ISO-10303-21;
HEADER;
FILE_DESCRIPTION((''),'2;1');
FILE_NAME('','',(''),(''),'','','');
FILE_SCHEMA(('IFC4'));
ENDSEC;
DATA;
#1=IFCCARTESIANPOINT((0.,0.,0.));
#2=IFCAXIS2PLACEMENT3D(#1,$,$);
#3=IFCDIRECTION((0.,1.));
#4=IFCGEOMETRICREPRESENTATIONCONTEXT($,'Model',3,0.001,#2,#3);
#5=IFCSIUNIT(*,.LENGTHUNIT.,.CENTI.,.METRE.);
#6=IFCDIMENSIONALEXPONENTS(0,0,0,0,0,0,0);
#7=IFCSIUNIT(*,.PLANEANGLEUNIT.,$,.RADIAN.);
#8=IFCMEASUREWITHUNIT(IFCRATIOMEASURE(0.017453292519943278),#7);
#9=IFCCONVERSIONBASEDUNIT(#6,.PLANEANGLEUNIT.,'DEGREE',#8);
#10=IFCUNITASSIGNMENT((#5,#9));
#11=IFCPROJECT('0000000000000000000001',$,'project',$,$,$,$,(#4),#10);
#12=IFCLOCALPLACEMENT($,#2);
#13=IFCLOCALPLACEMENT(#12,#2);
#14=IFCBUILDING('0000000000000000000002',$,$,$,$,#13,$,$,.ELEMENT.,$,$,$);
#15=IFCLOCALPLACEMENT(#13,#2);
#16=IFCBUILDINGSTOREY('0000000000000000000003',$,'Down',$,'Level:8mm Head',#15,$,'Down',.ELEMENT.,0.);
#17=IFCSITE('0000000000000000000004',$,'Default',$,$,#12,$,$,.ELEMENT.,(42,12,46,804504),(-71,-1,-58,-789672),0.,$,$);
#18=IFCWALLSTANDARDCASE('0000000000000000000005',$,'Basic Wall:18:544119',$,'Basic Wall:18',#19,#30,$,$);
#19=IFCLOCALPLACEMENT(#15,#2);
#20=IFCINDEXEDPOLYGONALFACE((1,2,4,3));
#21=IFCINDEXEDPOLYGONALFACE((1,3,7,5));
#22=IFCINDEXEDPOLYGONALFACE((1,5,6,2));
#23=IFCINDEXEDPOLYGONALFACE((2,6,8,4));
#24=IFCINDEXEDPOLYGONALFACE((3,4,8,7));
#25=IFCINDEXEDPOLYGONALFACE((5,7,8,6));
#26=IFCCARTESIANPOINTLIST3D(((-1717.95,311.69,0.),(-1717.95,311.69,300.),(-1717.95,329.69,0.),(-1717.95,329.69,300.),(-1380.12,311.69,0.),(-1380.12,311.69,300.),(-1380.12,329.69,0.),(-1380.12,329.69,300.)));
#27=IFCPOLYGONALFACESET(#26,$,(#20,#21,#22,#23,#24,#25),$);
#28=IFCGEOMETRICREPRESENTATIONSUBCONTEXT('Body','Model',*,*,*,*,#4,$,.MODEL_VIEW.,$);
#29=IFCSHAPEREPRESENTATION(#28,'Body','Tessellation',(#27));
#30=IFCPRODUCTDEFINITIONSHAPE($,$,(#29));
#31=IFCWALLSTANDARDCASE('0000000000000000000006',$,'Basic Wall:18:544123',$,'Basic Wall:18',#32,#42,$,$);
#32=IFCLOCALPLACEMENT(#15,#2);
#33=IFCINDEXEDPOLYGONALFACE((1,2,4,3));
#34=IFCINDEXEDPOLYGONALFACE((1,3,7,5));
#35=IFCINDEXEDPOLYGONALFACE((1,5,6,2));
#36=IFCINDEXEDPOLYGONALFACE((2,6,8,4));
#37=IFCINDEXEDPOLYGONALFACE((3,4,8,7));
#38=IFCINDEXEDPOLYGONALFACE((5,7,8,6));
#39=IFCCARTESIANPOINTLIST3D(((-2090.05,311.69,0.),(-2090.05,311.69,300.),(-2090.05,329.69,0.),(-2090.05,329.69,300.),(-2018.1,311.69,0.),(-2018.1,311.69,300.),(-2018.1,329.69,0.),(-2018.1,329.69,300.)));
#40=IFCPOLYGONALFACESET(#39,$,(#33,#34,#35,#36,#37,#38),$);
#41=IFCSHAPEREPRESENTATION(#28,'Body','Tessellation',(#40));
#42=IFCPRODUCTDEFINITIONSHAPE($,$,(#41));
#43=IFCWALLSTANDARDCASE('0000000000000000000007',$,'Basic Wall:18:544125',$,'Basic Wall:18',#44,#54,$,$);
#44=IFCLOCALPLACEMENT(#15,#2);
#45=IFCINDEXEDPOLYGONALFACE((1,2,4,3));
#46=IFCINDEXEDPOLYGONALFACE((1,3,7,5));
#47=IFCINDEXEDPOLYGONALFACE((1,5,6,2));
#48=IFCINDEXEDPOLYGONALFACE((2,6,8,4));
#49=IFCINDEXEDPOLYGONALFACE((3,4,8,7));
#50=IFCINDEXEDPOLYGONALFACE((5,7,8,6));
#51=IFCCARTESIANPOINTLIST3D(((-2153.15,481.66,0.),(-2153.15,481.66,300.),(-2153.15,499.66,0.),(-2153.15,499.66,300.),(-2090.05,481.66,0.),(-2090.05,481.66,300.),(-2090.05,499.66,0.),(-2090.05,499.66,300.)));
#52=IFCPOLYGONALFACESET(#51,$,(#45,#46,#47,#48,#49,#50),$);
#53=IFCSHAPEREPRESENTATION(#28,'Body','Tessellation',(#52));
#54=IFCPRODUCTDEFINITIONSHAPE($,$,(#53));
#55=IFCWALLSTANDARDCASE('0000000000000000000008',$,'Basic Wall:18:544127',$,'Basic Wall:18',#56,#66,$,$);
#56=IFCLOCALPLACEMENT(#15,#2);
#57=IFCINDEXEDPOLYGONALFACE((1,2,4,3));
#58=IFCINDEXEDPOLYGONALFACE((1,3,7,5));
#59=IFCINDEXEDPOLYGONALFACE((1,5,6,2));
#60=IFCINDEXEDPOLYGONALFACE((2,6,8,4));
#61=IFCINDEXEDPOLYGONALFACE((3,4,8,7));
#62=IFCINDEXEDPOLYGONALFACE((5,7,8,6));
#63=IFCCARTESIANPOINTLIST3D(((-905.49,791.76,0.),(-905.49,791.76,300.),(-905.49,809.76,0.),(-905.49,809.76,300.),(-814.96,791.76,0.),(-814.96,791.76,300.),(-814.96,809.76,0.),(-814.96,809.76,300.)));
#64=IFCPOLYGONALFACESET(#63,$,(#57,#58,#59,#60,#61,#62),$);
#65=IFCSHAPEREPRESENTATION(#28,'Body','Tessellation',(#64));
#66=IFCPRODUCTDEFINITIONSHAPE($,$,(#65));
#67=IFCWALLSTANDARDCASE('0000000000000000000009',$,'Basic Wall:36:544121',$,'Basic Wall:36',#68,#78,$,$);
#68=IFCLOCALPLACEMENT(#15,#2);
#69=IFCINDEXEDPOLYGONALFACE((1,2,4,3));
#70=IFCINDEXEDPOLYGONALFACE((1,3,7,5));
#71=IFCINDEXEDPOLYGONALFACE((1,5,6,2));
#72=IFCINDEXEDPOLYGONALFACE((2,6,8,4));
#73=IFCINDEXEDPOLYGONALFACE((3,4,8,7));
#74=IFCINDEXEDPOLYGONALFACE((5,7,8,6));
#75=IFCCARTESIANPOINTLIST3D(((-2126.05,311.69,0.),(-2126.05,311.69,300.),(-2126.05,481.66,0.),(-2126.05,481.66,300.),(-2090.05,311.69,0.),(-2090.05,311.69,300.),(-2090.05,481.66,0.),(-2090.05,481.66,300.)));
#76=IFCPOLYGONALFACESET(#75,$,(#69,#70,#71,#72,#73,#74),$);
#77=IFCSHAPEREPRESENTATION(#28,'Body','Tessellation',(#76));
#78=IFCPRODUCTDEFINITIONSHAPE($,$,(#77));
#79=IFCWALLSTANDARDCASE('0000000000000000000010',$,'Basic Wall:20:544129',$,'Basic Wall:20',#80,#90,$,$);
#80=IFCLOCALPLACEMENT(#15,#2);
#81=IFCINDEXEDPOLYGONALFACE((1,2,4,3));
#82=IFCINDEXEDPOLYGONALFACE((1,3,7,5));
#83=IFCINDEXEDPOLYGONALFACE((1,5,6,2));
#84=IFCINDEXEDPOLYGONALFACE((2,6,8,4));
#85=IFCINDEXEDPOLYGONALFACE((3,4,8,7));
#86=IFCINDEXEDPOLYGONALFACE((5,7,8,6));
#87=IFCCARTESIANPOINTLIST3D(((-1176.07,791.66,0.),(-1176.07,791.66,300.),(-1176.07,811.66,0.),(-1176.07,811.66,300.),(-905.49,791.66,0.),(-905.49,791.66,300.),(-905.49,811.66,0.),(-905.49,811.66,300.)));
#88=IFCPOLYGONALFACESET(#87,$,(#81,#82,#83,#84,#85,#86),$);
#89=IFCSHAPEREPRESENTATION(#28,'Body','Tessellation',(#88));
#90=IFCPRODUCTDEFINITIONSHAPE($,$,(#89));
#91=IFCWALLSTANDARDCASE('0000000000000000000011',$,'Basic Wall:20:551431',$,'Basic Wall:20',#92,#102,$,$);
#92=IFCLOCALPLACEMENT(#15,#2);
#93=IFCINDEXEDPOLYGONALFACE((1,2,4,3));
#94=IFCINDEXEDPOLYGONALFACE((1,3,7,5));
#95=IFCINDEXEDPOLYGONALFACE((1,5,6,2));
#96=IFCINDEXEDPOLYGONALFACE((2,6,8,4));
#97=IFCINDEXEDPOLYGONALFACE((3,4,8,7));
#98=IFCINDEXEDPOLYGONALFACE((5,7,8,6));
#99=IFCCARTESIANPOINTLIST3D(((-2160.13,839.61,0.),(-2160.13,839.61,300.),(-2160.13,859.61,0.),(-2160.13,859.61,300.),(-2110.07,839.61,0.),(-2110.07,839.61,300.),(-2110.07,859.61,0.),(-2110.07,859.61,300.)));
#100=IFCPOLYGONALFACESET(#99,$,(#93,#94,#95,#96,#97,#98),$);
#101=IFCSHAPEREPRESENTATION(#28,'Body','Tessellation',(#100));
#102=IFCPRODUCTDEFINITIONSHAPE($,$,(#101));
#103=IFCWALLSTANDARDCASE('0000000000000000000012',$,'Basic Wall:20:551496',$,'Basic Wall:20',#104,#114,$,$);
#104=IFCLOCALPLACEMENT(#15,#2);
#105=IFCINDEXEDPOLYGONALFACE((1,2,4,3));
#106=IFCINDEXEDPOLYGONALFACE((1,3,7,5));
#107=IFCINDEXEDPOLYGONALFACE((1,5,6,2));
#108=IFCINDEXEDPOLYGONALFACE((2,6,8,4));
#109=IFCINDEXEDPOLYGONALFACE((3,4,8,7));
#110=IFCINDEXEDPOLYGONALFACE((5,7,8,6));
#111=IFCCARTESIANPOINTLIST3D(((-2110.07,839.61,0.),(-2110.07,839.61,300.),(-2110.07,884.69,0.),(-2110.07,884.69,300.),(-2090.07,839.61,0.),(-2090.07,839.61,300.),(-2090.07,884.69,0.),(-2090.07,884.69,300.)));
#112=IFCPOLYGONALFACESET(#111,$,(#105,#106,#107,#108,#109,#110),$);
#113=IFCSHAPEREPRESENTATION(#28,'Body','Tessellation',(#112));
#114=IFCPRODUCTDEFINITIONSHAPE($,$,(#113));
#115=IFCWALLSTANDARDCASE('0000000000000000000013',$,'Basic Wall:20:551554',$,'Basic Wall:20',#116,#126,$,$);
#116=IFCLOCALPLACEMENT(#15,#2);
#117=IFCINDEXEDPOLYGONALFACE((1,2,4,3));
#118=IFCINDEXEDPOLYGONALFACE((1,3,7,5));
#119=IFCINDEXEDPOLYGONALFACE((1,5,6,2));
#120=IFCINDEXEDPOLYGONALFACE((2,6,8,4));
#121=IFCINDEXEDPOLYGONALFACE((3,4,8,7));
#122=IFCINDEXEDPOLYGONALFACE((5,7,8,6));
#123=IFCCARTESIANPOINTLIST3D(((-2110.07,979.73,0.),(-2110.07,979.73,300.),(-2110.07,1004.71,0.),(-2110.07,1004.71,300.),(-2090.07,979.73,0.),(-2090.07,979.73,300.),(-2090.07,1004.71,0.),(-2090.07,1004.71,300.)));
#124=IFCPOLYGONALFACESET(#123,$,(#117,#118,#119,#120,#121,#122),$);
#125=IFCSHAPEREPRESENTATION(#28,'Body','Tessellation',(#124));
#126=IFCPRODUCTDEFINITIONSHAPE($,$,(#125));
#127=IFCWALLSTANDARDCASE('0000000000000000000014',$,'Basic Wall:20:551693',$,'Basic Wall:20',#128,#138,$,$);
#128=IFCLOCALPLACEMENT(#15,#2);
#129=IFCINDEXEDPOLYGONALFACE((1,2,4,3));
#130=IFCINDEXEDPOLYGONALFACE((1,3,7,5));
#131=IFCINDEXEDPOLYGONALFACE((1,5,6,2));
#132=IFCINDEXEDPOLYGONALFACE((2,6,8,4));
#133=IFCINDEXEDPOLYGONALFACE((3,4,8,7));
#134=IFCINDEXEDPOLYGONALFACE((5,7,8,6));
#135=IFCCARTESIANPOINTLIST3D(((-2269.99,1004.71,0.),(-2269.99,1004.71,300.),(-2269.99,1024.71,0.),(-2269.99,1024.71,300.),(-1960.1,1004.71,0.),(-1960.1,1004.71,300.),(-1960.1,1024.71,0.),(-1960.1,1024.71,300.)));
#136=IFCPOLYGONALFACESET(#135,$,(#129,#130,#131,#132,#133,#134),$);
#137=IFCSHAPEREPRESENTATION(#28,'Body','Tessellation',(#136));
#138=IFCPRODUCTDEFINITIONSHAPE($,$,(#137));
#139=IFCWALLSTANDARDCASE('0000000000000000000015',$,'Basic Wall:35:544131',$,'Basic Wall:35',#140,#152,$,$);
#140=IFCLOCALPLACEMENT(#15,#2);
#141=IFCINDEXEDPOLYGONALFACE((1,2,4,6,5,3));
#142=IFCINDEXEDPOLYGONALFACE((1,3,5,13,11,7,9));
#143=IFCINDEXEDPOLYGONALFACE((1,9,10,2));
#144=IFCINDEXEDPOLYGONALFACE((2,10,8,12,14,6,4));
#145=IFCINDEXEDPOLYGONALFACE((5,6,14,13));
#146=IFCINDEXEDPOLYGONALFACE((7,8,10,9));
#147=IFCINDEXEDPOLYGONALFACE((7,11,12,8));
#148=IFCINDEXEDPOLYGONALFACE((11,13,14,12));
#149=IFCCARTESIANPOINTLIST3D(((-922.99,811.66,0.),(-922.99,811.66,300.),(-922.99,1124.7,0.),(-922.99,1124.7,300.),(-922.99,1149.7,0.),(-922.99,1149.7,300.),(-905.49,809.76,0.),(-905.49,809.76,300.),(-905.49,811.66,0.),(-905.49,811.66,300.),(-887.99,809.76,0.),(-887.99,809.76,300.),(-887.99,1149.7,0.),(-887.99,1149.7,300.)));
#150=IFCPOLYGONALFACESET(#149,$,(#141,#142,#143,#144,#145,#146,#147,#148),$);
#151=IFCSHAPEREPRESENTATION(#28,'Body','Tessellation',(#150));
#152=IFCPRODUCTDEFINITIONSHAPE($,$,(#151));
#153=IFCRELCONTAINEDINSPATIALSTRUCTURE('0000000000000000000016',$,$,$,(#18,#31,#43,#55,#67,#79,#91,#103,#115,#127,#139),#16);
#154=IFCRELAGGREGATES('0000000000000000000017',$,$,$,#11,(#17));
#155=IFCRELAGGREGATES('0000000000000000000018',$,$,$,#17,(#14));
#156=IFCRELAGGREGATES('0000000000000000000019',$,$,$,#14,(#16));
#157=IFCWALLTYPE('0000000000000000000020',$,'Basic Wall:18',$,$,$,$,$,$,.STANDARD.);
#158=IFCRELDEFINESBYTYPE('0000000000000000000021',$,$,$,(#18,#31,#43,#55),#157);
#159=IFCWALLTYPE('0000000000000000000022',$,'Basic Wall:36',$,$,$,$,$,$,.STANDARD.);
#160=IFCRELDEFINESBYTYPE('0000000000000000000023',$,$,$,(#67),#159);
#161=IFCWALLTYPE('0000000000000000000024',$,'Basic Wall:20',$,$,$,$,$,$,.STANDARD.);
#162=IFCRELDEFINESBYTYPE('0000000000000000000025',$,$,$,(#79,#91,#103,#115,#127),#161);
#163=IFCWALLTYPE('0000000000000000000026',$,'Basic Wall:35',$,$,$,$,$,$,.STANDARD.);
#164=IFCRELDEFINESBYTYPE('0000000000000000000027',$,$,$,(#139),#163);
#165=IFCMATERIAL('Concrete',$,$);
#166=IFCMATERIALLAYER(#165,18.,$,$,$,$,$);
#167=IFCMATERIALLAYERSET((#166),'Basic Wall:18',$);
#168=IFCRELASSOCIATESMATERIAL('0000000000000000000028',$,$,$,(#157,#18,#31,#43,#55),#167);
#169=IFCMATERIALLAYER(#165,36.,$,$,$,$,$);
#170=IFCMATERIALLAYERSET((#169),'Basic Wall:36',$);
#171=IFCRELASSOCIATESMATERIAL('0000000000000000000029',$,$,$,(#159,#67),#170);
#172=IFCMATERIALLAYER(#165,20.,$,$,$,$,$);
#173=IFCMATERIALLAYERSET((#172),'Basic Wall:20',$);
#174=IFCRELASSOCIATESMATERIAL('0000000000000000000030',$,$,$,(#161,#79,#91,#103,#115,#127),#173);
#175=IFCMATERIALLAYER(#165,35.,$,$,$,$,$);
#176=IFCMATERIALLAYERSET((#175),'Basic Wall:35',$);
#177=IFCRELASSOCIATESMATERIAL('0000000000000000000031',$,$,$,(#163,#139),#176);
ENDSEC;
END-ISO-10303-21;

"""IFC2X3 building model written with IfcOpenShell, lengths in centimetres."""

from ifc_helpers import new_model, entity, si_unit, converted_unit, direction, frame, frame_2d, origin, place, context, subcontext, project, spatial, polyline, rectangle, outline, extrude, material, layer, layer_set, layer_usage, type_object, element, save


model = new_model("IFC2X3")

# Units and contexts
model_context = context("Model", 3, precision=0.001, world=origin(), true_north=direction((0.0, 1.0)))
body_context = subcontext(model_context, "Body", "Model", "MODEL_VIEW")
ifc_project = project(units=[si_unit("LENGTHUNIT", "METRE", prefix="CENTI"), converted_unit("PLANEANGLEUNIT", "DEGREE", entity("IfcRatioMeasure", 0.017453292519943278), si_unit("PLANEANGLEUNIT", "RADIAN"), dimensions=[0, 0, 0, 0, 0, 0, 0])], contexts=[model_context])

# Site, building, storey
site_placement = place(None, origin())
site = spatial("IfcSite", under=ifc_project, at=site_placement, Name="Default", CompositionType="ELEMENT", RefLatitude=(42, 12, 46, 804504), RefLongitude=(-71, -1, -58, -789672), RefElevation=0.0)
building_placement = place(site_placement, origin())
building = spatial("IfcBuilding", under=site, at=building_placement, CompositionType="ELEMENT")
storey_placement = place(building_placement, origin())
storey = spatial("IfcBuildingStorey", under=building, at=storey_placement, Name="Down", ObjectType="Level:8mm Head", LongName="Down", CompositionType="ELEMENT", Elevation=0.0)

# Shared definitions
ifc_material = material(Name="Concrete")

# Walls
ifc_layer_1 = layer(ifc_material, 18.0)
ifc_layer_set_1 = layer_set([ifc_layer_1], Name="Basic Wall:18")
wall_type_1 = type_object("IfcWallType", Name="Basic Wall:18", PredefinedType="STANDARD", material=ifc_layer_set_1)
ifc_layer_usage_1 = layer_usage(ifc_layer_set_1, "AXIS2", "POSITIVE", -9.0)
wall_1_placement = place(storey_placement, frame((-1380.12, 320.69, 0.0), z_axis=(0.0, 0.0, 1.0), x_axis=(-1.0, 0.0, 0.0)))
element("IfcWallStandardCase", 1, at=wall_1_placement, inside=storey, type_object=wall_type_1, material=ifc_layer_usage_1, Name="Basic Wall:18:544119", ObjectType="Basic Wall:18", context=body_context, shape_type="SweptSolid", body=[
    extrude(rectangle(XDim=337.83, YDim=18.0, at=frame_2d((168.91, 0.0), x_axis=(-1.0, 0.0))), origin(), (0.0, 0.0, 1.0), 300.0),
])
ifc_layer_usage_2 = layer_usage(ifc_layer_set_1, "AXIS2", "POSITIVE", -9.0)
wall_2_placement = place(storey_placement, frame((-2018.1, 320.69, 0.0), z_axis=(0.0, 0.0, 1.0), x_axis=(-1.0, 0.0, 0.0)))
element("IfcWallStandardCase", 2, at=wall_2_placement, inside=storey, type_object=wall_type_1, material=ifc_layer_usage_2, Name="Basic Wall:18:544123", ObjectType="Basic Wall:18", context=body_context, shape_type="SweptSolid", body=[
    extrude(rectangle(XDim=71.95, YDim=18.0, at=frame_2d((35.98, 0.0), x_axis=(-1.0, 0.0))), origin(), (0.0, 0.0, 1.0), 300.0),
])
ifc_layer_usage_3 = layer_usage(ifc_layer_set_1, "AXIS2", "POSITIVE", -9.0)
wall_3_placement = place(storey_placement, frame((-2090.05, 490.66, 0.0), z_axis=(0.0, 0.0, 1.0), x_axis=(-1.0, 0.0, 0.0)))
element("IfcWallStandardCase", 3, at=wall_3_placement, inside=storey, type_object=wall_type_1, material=ifc_layer_usage_3, Name="Basic Wall:18:544125", ObjectType="Basic Wall:18", context=body_context, shape_type="SweptSolid", body=[
    extrude(rectangle(XDim=63.09, YDim=18.0, at=frame_2d((31.55, 0.0), x_axis=(-1.0, 0.0))), origin(), (0.0, 0.0, 1.0), 300.0),
])
ifc_layer_usage_4 = layer_usage(ifc_layer_set_1, "AXIS2", "POSITIVE", -9.0)
wall_4_placement = place(storey_placement, frame((-814.96, 800.76, 0.0), z_axis=(0.0, 0.0, 1.0), x_axis=(-1.0, 0.0, 0.0)))
element("IfcWallStandardCase", 4, at=wall_4_placement, inside=storey, type_object=wall_type_1, material=ifc_layer_usage_4, Name="Basic Wall:18:544127", ObjectType="Basic Wall:18", context=body_context, shape_type="SweptSolid", body=[
    extrude(rectangle(XDim=90.53, YDim=18.0, at=frame_2d((45.26, 0.0), x_axis=(-1.0, 0.0))), origin(), (0.0, 0.0, 1.0), 300.0),
])
ifc_layer_2 = layer(ifc_material, 36.0)
ifc_layer_set_2 = layer_set([ifc_layer_2], Name="Basic Wall:36")
ifc_layer_usage_5 = layer_usage(ifc_layer_set_2, "AXIS2", "NEGATIVE", 18.0)
wall_type_2 = type_object("IfcWallType", Name="Basic Wall:36", PredefinedType="STANDARD", material=ifc_layer_set_2)
wall_5_placement = place(storey_placement, frame((-2108.05, 311.69, 0.0), z_axis=(0.0, 0.0, 1.0), x_axis=(0.0, 1.0, 0.0)))
element("IfcWallStandardCase", 5, at=wall_5_placement, inside=storey, type_object=wall_type_2, material=ifc_layer_usage_5, Name="Basic Wall:36:544121", ObjectType="Basic Wall:36", context=body_context, shape_type="SweptSolid", body=[
    extrude(rectangle(XDim=169.97, YDim=36.0, at=frame_2d((84.99, 0.0), x_axis=(-1.0, 0.0))), origin(), (0.0, 0.0, 1.0), 300.0),
])
ifc_layer_3 = layer(ifc_material, 20.0)
ifc_layer_set_3 = layer_set([ifc_layer_3], Name="Basic Wall:20")
ifc_layer_usage_6 = layer_usage(ifc_layer_set_3, "AXIS2", "NEGATIVE", 10.0)
wall_type_3 = type_object("IfcWallType", Name="Basic Wall:20", PredefinedType="STANDARD", material=ifc_layer_set_3)
wall_6_placement = place(storey_placement, frame((-1176.07, 801.66, 0.0)))
element("IfcWallStandardCase", 6, at=wall_6_placement, inside=storey, type_object=wall_type_3, material=ifc_layer_usage_6, Name="Basic Wall:20:544129", ObjectType="Basic Wall:20", context=body_context, shape_type="SweptSolid", body=[
    extrude(rectangle(XDim=270.58, YDim=20.0, at=frame_2d((135.29, 0.0), x_axis=(-1.0, 0.0))), origin(), (0.0, 0.0, 1.0), 300.0),
])
ifc_layer_usage_7 = layer_usage(ifc_layer_set_3, "AXIS2", "POSITIVE", -10.0)
wall_7_placement = place(storey_placement, frame((-2160.13, 849.61, 0.0)))
element("IfcWallStandardCase", 7, at=wall_7_placement, inside=storey, type_object=wall_type_3, material=ifc_layer_usage_7, Name="Basic Wall:20:551431", ObjectType="Basic Wall:20", context=body_context, shape_type="SweptSolid", body=[
    extrude(rectangle(XDim=50.06, YDim=20.0, at=frame_2d((25.03, 0.0), x_axis=(-1.0, 0.0))), origin(), (0.0, 0.0, 1.0), 300.0),
])
ifc_layer_usage_8 = layer_usage(ifc_layer_set_3, "AXIS2", "POSITIVE", -10.0)
wall_8_placement = place(storey_placement, frame((-2100.07, 839.61, 0.0), z_axis=(0.0, 0.0, 1.0), x_axis=(0.0, 1.0, 0.0)))
element("IfcWallStandardCase", 8, at=wall_8_placement, inside=storey, type_object=wall_type_3, material=ifc_layer_usage_8, Name="Basic Wall:20:551496", ObjectType="Basic Wall:20", context=body_context, shape_type="SweptSolid", body=[
    extrude(rectangle(XDim=45.09, YDim=20.0, at=frame_2d((22.54, 0.0), x_axis=(-1.0, 0.0))), origin(), (0.0, 0.0, 1.0), 300.0),
])
ifc_layer_usage_9 = layer_usage(ifc_layer_set_3, "AXIS2", "POSITIVE", -10.0)
wall_9_placement = place(storey_placement, frame((-2100.07, 979.73, 0.0), z_axis=(0.0, 0.0, 1.0), x_axis=(0.0, 1.0, 0.0)))
element("IfcWallStandardCase", 9, at=wall_9_placement, inside=storey, type_object=wall_type_3, material=ifc_layer_usage_9, Name="Basic Wall:20:551554", ObjectType="Basic Wall:20", context=body_context, shape_type="SweptSolid", body=[
    extrude(rectangle(XDim=24.98, YDim=20.0, at=frame_2d((12.49, 0.0), x_axis=(-1.0, 0.0))), origin(), (0.0, 0.0, 1.0), 300.0),
])
ifc_layer_usage_10 = layer_usage(ifc_layer_set_3, "AXIS2", "NEGATIVE", 10.0)
wall_10_placement = place(storey_placement, frame((-1960.1, 1014.71, 0.0), z_axis=(0.0, 0.0, 1.0), x_axis=(-1.0, 0.0, 0.0)))
element("IfcWallStandardCase", 10, at=wall_10_placement, inside=storey, type_object=wall_type_3, material=ifc_layer_usage_10, Name="Basic Wall:20:551693", ObjectType="Basic Wall:20", context=body_context, shape_type="SweptSolid", body=[
    extrude(rectangle(XDim=309.89, YDim=20.0, at=frame_2d((154.94, 0.0), x_axis=(-1.0, 0.0))), origin(), (0.0, 0.0, 1.0), 300.0),
])
ifc_layer_4 = layer(ifc_material, 35.0)
ifc_layer_set_4 = layer_set([ifc_layer_4], Name="Basic Wall:35")
ifc_layer_usage_11 = layer_usage(ifc_layer_set_4, "AXIS2", "NEGATIVE", 17.5)
wall_type_4 = type_object("IfcWallType", Name="Basic Wall:35", PredefinedType="STANDARD", material=ifc_layer_set_4)
wall_11_placement = place(storey_placement, frame((-905.49, 809.76, 0.0), z_axis=(0.0, 0.0, 1.0), x_axis=(0.0, 1.0, 0.0)))
element("IfcWallStandardCase", 11, at=wall_11_placement, inside=storey, type_object=wall_type_4, material=ifc_layer_usage_11, Name="Basic Wall:35:544131", ObjectType="Basic Wall:35", context=body_context, shape_type="SweptSolid", body=[
    extrude(outline(polyline([(339.94, -17.5), (339.94, 17.5), (314.94, 17.5), (1.91, 17.5), (1.91, 0.0), (0.0, 0.0), (0.0, -17.5), (339.94, -17.5)])), origin(), (0.0, 0.0, 1.0), 300.0),
])

save(model, "model.ifc")
